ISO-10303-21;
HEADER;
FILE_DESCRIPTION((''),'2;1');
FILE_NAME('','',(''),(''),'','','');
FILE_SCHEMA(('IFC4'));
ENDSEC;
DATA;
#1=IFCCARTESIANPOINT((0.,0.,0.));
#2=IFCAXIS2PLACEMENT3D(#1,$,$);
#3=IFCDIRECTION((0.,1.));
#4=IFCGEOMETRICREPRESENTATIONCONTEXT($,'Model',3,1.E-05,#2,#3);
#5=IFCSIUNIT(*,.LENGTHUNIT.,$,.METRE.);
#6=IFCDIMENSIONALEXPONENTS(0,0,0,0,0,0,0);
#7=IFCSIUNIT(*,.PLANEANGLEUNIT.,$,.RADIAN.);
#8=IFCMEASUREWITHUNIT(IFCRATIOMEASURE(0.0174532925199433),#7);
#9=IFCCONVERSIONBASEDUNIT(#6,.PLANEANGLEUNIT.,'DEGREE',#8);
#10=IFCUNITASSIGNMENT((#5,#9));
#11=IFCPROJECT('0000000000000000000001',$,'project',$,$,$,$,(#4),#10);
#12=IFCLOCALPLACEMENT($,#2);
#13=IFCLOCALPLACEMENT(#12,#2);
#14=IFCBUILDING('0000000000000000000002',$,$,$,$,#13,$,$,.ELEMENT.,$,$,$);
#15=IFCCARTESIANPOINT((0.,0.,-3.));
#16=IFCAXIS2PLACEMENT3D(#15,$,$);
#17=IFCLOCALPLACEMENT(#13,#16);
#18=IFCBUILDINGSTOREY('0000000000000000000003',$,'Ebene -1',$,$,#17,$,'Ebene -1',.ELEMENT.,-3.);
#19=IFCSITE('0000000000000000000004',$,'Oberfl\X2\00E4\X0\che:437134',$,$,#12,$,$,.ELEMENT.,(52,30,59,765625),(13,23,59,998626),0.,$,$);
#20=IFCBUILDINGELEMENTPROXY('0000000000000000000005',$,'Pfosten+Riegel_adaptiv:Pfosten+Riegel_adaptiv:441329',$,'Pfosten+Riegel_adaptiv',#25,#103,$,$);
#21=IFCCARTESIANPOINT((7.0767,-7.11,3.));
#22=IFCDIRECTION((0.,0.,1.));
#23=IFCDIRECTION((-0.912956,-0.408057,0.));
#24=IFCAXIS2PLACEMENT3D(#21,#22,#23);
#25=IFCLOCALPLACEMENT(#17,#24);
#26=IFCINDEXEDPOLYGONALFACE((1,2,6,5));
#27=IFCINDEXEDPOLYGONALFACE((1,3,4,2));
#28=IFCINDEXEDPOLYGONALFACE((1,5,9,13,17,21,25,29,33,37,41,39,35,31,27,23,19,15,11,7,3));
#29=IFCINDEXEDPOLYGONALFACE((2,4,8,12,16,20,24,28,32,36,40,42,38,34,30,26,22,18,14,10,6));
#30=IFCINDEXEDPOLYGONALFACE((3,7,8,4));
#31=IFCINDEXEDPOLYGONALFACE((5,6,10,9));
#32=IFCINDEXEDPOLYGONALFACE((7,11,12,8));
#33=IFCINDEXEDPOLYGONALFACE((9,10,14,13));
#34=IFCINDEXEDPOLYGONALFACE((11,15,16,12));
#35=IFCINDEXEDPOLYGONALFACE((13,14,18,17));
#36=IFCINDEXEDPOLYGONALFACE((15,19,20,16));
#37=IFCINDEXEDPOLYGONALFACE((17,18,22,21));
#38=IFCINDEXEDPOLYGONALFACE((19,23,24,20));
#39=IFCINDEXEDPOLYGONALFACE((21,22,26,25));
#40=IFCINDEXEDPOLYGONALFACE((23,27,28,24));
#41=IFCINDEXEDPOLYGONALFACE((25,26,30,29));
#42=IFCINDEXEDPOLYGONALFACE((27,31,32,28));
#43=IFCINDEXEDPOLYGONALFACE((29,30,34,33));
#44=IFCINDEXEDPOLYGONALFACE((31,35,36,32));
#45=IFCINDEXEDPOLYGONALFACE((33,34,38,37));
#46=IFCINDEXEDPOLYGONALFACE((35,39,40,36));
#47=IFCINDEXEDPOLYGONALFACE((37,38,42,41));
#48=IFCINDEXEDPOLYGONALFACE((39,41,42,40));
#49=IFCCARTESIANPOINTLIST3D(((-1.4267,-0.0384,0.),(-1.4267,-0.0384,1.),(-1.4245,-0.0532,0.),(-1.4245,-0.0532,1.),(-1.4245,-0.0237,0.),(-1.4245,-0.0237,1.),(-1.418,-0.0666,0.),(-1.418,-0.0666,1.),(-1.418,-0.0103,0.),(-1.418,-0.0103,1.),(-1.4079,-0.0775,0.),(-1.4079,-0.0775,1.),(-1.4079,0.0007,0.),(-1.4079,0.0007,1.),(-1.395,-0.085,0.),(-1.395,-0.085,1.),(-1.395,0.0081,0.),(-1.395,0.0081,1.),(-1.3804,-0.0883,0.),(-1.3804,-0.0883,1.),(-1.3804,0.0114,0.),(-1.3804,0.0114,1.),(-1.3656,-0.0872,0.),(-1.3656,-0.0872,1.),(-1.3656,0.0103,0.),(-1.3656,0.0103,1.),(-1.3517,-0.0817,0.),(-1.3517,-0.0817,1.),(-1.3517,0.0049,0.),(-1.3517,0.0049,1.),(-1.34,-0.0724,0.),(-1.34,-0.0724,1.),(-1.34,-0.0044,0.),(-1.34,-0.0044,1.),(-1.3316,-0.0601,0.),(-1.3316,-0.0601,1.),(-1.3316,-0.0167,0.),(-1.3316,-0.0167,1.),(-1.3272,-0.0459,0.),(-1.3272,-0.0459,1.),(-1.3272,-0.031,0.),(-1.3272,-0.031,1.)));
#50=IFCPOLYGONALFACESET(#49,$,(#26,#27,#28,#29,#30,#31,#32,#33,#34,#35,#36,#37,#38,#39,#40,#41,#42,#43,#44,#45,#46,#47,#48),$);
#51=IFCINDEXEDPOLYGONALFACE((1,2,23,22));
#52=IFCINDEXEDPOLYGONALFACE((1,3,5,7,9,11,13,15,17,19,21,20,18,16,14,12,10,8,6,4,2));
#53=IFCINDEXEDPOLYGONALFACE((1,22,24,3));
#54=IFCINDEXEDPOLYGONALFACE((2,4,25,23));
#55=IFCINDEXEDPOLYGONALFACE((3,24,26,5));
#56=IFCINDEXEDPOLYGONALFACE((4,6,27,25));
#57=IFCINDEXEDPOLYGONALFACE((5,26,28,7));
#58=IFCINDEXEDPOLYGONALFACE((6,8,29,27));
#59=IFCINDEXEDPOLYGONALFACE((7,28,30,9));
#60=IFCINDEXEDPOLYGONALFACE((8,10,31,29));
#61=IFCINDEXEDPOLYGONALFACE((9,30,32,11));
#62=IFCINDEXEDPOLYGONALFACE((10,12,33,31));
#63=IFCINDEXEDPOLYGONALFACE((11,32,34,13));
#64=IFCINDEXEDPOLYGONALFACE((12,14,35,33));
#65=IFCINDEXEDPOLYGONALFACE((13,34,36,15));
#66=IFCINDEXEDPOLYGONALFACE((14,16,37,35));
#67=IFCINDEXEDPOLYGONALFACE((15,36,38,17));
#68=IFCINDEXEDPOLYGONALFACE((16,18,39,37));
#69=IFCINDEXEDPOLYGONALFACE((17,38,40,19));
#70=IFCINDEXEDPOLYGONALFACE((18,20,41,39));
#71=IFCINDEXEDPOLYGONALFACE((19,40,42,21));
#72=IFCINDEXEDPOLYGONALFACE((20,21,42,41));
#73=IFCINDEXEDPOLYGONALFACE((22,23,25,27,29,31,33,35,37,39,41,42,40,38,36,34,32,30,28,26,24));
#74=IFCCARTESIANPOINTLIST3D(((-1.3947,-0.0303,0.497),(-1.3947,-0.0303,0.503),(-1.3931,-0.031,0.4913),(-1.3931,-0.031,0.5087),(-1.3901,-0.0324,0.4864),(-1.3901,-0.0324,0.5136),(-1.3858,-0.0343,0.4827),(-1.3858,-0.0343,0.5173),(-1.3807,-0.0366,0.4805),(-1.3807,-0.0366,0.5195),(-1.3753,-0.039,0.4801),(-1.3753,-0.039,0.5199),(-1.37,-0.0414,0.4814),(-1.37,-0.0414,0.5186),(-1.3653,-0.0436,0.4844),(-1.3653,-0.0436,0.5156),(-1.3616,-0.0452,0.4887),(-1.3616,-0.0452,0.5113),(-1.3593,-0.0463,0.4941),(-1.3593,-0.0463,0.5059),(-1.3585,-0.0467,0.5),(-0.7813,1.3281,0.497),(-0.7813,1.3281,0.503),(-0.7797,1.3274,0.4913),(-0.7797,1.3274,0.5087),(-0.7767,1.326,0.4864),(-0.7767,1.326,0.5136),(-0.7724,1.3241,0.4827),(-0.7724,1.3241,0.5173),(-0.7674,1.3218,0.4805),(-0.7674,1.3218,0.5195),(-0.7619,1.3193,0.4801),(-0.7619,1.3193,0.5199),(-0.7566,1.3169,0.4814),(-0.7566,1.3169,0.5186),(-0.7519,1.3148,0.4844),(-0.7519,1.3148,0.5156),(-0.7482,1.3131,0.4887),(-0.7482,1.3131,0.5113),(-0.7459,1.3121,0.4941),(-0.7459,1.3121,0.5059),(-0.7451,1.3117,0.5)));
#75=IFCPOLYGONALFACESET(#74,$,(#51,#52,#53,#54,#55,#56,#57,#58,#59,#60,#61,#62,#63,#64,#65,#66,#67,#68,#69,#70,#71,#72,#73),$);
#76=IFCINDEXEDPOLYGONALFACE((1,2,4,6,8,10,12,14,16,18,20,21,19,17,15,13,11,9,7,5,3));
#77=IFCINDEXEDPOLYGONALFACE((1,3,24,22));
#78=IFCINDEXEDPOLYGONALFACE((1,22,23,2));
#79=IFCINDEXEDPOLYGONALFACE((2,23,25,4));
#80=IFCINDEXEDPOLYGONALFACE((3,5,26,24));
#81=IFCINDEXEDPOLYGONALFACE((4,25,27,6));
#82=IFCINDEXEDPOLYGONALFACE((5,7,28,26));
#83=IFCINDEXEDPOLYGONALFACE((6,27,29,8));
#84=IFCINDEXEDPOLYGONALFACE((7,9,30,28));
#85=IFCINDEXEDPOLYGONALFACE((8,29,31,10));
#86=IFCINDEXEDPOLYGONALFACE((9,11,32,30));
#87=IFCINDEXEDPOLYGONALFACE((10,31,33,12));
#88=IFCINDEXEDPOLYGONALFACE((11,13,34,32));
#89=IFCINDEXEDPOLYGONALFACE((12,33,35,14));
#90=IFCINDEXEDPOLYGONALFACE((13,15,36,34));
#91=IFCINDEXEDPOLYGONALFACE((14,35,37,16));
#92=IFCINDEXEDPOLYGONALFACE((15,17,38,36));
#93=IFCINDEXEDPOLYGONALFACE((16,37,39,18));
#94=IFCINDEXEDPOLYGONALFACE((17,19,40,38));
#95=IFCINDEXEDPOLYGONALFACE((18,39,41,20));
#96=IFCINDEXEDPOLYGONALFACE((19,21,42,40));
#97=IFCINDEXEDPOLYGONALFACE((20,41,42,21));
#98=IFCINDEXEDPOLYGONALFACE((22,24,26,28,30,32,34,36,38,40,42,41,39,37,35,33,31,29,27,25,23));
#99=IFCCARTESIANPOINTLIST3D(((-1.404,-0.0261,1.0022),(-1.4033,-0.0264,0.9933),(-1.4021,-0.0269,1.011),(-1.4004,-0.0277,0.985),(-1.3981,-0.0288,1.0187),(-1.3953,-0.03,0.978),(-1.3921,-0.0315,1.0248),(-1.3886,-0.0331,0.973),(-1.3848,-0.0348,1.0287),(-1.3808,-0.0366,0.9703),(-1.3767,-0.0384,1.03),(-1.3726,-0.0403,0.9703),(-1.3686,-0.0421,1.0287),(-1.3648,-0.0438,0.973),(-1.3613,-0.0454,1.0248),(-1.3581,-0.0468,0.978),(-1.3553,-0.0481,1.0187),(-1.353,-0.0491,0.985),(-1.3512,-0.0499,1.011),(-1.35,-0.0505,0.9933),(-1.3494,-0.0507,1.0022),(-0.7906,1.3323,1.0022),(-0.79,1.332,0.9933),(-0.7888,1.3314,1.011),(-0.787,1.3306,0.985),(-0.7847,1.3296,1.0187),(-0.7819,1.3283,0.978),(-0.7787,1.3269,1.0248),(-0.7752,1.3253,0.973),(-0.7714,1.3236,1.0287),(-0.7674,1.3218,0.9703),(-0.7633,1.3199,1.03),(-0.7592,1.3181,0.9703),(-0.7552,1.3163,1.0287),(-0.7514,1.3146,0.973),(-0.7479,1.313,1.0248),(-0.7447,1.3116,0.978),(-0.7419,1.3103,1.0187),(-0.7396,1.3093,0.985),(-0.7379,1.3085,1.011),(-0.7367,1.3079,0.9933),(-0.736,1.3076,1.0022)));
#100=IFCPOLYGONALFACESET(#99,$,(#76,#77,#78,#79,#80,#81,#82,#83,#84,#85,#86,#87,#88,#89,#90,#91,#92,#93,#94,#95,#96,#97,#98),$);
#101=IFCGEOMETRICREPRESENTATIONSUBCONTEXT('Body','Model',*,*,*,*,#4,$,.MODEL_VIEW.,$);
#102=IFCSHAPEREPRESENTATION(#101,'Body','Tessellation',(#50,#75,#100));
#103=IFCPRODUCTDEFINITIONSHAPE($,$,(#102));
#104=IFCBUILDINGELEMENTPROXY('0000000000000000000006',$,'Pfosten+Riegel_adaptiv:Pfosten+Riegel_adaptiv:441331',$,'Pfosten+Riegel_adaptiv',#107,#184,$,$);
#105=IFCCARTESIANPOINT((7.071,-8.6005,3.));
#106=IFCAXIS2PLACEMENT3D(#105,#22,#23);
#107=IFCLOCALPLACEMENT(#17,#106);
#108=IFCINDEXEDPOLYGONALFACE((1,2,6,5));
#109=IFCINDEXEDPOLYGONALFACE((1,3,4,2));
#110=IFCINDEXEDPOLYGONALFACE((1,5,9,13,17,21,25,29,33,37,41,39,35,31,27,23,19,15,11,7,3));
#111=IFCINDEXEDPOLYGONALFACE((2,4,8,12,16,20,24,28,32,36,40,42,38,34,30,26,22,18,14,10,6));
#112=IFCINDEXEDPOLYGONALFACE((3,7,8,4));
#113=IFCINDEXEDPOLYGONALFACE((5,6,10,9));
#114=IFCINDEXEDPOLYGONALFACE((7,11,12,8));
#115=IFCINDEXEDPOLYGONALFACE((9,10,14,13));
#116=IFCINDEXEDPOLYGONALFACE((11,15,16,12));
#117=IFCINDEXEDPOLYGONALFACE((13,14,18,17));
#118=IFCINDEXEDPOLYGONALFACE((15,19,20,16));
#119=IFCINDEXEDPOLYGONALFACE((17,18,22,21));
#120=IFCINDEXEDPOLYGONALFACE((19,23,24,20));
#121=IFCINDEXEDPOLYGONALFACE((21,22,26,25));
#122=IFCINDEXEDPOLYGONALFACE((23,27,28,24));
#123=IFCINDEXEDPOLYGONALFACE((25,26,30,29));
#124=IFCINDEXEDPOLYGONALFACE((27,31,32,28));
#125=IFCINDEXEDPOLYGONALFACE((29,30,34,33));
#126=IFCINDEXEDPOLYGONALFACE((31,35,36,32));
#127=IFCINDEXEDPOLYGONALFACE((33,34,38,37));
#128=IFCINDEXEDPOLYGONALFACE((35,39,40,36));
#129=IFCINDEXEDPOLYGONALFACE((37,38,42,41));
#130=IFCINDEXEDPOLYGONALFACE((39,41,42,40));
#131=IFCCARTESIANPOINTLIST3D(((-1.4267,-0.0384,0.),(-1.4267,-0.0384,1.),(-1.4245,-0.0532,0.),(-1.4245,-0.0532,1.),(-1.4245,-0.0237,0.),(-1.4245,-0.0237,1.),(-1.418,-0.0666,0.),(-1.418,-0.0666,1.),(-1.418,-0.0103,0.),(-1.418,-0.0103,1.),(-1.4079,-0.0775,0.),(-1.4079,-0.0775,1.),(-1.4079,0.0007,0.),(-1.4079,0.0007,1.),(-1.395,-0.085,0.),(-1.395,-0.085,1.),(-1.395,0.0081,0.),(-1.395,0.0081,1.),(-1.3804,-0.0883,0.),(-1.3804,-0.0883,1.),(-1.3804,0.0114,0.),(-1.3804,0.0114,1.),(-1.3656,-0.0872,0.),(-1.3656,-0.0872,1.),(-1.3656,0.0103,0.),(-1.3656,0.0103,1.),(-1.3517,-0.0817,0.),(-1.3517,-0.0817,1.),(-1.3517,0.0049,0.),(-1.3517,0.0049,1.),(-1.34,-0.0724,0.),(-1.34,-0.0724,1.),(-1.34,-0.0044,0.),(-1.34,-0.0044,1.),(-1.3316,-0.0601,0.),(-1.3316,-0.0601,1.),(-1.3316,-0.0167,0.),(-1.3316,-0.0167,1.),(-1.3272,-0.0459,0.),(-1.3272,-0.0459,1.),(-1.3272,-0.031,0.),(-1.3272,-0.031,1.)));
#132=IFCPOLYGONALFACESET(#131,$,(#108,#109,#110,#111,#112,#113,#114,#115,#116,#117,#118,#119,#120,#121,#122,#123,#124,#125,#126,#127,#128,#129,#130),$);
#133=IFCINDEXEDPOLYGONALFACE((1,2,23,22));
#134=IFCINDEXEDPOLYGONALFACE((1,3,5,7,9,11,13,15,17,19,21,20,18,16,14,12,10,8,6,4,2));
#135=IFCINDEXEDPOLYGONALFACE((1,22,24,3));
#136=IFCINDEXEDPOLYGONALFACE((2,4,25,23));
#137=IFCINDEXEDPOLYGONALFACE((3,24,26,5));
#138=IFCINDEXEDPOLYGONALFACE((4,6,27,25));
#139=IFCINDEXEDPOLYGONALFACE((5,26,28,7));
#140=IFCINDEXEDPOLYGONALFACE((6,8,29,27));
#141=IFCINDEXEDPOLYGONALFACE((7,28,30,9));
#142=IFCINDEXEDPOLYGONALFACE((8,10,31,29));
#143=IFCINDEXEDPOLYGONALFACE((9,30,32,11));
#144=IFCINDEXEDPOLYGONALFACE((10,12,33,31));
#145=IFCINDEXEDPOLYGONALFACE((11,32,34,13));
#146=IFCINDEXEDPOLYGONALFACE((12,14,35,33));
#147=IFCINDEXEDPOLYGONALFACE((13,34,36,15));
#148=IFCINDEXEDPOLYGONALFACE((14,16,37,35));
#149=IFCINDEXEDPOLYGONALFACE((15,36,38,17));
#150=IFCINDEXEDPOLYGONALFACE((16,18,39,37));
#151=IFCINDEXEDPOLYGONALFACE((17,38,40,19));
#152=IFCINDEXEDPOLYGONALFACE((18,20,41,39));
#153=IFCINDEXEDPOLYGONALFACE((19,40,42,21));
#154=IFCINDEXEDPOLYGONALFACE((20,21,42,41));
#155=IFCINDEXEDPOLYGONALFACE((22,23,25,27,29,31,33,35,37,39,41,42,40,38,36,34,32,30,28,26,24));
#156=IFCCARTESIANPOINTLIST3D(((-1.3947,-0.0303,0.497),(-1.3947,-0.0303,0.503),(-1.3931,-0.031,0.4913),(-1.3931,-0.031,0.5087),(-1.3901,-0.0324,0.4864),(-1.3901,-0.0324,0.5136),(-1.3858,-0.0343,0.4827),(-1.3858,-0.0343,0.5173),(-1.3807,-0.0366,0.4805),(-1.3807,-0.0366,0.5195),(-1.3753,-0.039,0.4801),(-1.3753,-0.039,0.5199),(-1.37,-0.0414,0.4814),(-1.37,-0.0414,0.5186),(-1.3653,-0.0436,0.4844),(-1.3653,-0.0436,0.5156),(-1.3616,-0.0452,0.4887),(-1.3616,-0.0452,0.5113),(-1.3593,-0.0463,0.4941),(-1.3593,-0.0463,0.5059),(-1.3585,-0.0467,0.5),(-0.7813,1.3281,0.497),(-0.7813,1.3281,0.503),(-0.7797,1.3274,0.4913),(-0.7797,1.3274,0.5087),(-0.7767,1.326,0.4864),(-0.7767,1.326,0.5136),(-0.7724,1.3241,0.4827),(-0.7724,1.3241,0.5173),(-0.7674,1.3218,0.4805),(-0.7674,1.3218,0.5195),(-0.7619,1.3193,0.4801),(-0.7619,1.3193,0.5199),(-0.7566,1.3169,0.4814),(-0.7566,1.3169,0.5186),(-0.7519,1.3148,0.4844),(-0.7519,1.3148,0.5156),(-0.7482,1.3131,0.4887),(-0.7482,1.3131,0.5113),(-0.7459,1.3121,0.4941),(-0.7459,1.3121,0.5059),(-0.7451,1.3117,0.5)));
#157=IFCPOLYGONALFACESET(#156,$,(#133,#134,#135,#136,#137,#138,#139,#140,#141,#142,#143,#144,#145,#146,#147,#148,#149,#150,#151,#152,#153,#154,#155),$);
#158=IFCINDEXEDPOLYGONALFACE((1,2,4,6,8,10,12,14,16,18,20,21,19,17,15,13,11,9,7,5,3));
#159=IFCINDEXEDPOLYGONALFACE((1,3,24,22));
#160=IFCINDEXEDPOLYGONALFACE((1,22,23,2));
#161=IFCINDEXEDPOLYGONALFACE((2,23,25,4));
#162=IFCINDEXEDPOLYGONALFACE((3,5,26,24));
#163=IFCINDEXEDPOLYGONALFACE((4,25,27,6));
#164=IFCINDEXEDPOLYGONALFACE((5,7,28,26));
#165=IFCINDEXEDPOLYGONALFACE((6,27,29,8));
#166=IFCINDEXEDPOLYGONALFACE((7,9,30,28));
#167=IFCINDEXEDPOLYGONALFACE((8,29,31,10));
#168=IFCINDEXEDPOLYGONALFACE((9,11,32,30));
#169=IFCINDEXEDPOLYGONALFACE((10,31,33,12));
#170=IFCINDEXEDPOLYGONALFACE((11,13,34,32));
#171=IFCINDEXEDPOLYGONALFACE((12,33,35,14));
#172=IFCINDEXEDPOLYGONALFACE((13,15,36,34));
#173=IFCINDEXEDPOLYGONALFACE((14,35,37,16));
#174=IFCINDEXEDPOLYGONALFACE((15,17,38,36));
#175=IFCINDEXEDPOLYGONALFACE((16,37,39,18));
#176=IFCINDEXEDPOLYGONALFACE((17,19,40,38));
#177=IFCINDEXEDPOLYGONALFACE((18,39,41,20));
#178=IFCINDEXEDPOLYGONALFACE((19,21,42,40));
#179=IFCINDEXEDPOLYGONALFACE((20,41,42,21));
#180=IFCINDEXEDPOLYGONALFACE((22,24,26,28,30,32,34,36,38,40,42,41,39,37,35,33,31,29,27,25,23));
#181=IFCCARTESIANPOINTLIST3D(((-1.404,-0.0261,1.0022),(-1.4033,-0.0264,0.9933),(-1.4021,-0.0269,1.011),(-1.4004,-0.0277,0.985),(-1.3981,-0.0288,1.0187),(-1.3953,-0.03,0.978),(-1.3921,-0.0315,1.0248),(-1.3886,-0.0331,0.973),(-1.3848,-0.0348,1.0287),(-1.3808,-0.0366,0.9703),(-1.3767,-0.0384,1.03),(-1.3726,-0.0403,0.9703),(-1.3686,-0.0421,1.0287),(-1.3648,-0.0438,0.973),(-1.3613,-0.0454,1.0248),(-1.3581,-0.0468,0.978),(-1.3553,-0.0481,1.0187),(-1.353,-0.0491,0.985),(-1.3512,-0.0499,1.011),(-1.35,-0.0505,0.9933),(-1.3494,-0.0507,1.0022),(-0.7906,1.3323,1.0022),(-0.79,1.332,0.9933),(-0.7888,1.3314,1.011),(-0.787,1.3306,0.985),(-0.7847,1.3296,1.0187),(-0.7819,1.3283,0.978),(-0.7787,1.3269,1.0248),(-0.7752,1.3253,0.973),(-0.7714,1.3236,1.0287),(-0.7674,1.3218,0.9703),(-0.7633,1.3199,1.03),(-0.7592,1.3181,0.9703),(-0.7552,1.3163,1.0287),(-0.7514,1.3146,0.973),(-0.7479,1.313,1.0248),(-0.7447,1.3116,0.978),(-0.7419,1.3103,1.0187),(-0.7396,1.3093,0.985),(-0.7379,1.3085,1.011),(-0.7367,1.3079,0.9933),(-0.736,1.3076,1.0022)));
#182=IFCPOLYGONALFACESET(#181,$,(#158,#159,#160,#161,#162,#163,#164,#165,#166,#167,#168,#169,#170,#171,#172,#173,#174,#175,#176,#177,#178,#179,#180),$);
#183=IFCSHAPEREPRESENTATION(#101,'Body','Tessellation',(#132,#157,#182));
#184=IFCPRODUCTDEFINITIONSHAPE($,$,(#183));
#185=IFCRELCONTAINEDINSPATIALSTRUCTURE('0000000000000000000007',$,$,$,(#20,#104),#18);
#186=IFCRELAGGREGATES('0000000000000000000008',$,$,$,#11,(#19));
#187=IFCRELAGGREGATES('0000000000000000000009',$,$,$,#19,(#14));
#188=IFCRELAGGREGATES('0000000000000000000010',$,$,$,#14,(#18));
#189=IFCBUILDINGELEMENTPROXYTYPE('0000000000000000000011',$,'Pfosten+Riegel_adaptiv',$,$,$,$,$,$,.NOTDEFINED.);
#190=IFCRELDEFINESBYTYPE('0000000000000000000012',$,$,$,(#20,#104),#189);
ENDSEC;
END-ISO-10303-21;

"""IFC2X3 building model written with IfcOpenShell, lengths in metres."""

from ifc_helpers import new_model, entity, si_unit, converted_unit, direction, frame, frame_2d, origin, place, context, subcontext, project, spatial, circle, extrude, source, transform, mapped, type_object, type_shapes, element, save


model = new_model("IFC2X3")

# Units and contexts
model_context = context("Model", 3, precision=1e-05, world=origin(), true_north=direction((0.0, 1.0)))
body_context = subcontext(model_context, "Body", "Model", "MODEL_VIEW")
ifc_project = project(units=[si_unit("LENGTHUNIT", "METRE"), converted_unit("PLANEANGLEUNIT", "DEGREE", entity("IfcRatioMeasure", 0.0174532925199433), si_unit("PLANEANGLEUNIT", "RADIAN"), dimensions=[0, 0, 0, 0, 0, 0, 0])], contexts=[model_context])

# Site, building, storey
site_placement = place(None, origin())
site = spatial("IfcSite", under=ifc_project, at=site_placement, Name="Oberfläche:437134", CompositionType="ELEMENT", RefLatitude=(52, 30, 59, 765625), RefLongitude=(13, 23, 59, 998626), RefElevation=0.0)
building_placement = place(site_placement, origin())
building = spatial("IfcBuilding", under=site, at=building_placement, CompositionType="ELEMENT")
storey_placement = place(building_placement, frame((0.0, 0.0, -3.0)))
storey = spatial("IfcBuildingStorey", under=building, at=storey_placement, Name="Ebene -1", LongName="Ebene -1", CompositionType="ELEMENT", Elevation=-3.0)

# Building element proxies
building_element_proxy_type_1 = type_object("IfcBuildingElementProxyType", Name="Pfosten+Riegel_adaptiv", PredefinedType="NOTDEFINED")
shared_shape_1 = source(origin(), body_context, "Body", "SweptSolid", [
    extrude(circle(Radius=0.05, at=frame_2d((0.0, 0.0), x_axis=(1.0, 0.0))), frame((-1.3767, -0.0384, 0.0), z_axis=(0.0, 0.0, 1.0), x_axis=(-1.0, 0.0, 0.0)), (0.0, 0.0, 1.0), 1.0),
    extrude(circle(Radius=0.02, at=frame_2d((0.0, 0.0), x_axis=(1.0, 0.0))), frame((-1.3767, -0.0384, 0.5), z_axis=(0.411546, 0.911389, 0.0), x_axis=(0.911389, -0.411546, 0.0)), (0.0, 0.0, 1.0), 1.4904),
    extrude(circle(Radius=0.03, at=frame_2d((0.0, 0.0), x_axis=(1.0, 0.0))), frame((-1.3767, -0.0384, 1.0), z_axis=(0.411546, 0.911389, 0.0), x_axis=(0.0, 0.0, 1.0)), (0.0, 0.0, 1.0), 1.4904),
])
type_shapes(building_element_proxy_type_1, [shared_shape_1])
for number, where, z_axis, x_axis, name in (
    (1, (7.0767, -7.11, 3.0), (0.0, 0.0, 1.0), (-0.912956, -0.408057, 0.0), "Pfosten+Riegel_adaptiv:Pfosten+Riegel_adaptiv:441329"),
    (2, (7.071, -8.6005, 3.0), (0.0, 0.0, 1.0), (-0.912956, -0.408057, 0.0), "Pfosten+Riegel_adaptiv:Pfosten+Riegel_adaptiv:441331"),
):
    element("IfcBuildingElementProxy", number, at=place(storey_placement, frame(where, z_axis=z_axis, x_axis=x_axis)), inside=storey, type_object=building_element_proxy_type_1, Name=name, ObjectType="Pfosten+Riegel_adaptiv", context=body_context, shape_type="MappedRepresentation", body=[
        mapped(shared_shape_1, transform((0.0, 0.0, 0.0), scale=1.0)),
    ])

save(model, "model.ifc")
